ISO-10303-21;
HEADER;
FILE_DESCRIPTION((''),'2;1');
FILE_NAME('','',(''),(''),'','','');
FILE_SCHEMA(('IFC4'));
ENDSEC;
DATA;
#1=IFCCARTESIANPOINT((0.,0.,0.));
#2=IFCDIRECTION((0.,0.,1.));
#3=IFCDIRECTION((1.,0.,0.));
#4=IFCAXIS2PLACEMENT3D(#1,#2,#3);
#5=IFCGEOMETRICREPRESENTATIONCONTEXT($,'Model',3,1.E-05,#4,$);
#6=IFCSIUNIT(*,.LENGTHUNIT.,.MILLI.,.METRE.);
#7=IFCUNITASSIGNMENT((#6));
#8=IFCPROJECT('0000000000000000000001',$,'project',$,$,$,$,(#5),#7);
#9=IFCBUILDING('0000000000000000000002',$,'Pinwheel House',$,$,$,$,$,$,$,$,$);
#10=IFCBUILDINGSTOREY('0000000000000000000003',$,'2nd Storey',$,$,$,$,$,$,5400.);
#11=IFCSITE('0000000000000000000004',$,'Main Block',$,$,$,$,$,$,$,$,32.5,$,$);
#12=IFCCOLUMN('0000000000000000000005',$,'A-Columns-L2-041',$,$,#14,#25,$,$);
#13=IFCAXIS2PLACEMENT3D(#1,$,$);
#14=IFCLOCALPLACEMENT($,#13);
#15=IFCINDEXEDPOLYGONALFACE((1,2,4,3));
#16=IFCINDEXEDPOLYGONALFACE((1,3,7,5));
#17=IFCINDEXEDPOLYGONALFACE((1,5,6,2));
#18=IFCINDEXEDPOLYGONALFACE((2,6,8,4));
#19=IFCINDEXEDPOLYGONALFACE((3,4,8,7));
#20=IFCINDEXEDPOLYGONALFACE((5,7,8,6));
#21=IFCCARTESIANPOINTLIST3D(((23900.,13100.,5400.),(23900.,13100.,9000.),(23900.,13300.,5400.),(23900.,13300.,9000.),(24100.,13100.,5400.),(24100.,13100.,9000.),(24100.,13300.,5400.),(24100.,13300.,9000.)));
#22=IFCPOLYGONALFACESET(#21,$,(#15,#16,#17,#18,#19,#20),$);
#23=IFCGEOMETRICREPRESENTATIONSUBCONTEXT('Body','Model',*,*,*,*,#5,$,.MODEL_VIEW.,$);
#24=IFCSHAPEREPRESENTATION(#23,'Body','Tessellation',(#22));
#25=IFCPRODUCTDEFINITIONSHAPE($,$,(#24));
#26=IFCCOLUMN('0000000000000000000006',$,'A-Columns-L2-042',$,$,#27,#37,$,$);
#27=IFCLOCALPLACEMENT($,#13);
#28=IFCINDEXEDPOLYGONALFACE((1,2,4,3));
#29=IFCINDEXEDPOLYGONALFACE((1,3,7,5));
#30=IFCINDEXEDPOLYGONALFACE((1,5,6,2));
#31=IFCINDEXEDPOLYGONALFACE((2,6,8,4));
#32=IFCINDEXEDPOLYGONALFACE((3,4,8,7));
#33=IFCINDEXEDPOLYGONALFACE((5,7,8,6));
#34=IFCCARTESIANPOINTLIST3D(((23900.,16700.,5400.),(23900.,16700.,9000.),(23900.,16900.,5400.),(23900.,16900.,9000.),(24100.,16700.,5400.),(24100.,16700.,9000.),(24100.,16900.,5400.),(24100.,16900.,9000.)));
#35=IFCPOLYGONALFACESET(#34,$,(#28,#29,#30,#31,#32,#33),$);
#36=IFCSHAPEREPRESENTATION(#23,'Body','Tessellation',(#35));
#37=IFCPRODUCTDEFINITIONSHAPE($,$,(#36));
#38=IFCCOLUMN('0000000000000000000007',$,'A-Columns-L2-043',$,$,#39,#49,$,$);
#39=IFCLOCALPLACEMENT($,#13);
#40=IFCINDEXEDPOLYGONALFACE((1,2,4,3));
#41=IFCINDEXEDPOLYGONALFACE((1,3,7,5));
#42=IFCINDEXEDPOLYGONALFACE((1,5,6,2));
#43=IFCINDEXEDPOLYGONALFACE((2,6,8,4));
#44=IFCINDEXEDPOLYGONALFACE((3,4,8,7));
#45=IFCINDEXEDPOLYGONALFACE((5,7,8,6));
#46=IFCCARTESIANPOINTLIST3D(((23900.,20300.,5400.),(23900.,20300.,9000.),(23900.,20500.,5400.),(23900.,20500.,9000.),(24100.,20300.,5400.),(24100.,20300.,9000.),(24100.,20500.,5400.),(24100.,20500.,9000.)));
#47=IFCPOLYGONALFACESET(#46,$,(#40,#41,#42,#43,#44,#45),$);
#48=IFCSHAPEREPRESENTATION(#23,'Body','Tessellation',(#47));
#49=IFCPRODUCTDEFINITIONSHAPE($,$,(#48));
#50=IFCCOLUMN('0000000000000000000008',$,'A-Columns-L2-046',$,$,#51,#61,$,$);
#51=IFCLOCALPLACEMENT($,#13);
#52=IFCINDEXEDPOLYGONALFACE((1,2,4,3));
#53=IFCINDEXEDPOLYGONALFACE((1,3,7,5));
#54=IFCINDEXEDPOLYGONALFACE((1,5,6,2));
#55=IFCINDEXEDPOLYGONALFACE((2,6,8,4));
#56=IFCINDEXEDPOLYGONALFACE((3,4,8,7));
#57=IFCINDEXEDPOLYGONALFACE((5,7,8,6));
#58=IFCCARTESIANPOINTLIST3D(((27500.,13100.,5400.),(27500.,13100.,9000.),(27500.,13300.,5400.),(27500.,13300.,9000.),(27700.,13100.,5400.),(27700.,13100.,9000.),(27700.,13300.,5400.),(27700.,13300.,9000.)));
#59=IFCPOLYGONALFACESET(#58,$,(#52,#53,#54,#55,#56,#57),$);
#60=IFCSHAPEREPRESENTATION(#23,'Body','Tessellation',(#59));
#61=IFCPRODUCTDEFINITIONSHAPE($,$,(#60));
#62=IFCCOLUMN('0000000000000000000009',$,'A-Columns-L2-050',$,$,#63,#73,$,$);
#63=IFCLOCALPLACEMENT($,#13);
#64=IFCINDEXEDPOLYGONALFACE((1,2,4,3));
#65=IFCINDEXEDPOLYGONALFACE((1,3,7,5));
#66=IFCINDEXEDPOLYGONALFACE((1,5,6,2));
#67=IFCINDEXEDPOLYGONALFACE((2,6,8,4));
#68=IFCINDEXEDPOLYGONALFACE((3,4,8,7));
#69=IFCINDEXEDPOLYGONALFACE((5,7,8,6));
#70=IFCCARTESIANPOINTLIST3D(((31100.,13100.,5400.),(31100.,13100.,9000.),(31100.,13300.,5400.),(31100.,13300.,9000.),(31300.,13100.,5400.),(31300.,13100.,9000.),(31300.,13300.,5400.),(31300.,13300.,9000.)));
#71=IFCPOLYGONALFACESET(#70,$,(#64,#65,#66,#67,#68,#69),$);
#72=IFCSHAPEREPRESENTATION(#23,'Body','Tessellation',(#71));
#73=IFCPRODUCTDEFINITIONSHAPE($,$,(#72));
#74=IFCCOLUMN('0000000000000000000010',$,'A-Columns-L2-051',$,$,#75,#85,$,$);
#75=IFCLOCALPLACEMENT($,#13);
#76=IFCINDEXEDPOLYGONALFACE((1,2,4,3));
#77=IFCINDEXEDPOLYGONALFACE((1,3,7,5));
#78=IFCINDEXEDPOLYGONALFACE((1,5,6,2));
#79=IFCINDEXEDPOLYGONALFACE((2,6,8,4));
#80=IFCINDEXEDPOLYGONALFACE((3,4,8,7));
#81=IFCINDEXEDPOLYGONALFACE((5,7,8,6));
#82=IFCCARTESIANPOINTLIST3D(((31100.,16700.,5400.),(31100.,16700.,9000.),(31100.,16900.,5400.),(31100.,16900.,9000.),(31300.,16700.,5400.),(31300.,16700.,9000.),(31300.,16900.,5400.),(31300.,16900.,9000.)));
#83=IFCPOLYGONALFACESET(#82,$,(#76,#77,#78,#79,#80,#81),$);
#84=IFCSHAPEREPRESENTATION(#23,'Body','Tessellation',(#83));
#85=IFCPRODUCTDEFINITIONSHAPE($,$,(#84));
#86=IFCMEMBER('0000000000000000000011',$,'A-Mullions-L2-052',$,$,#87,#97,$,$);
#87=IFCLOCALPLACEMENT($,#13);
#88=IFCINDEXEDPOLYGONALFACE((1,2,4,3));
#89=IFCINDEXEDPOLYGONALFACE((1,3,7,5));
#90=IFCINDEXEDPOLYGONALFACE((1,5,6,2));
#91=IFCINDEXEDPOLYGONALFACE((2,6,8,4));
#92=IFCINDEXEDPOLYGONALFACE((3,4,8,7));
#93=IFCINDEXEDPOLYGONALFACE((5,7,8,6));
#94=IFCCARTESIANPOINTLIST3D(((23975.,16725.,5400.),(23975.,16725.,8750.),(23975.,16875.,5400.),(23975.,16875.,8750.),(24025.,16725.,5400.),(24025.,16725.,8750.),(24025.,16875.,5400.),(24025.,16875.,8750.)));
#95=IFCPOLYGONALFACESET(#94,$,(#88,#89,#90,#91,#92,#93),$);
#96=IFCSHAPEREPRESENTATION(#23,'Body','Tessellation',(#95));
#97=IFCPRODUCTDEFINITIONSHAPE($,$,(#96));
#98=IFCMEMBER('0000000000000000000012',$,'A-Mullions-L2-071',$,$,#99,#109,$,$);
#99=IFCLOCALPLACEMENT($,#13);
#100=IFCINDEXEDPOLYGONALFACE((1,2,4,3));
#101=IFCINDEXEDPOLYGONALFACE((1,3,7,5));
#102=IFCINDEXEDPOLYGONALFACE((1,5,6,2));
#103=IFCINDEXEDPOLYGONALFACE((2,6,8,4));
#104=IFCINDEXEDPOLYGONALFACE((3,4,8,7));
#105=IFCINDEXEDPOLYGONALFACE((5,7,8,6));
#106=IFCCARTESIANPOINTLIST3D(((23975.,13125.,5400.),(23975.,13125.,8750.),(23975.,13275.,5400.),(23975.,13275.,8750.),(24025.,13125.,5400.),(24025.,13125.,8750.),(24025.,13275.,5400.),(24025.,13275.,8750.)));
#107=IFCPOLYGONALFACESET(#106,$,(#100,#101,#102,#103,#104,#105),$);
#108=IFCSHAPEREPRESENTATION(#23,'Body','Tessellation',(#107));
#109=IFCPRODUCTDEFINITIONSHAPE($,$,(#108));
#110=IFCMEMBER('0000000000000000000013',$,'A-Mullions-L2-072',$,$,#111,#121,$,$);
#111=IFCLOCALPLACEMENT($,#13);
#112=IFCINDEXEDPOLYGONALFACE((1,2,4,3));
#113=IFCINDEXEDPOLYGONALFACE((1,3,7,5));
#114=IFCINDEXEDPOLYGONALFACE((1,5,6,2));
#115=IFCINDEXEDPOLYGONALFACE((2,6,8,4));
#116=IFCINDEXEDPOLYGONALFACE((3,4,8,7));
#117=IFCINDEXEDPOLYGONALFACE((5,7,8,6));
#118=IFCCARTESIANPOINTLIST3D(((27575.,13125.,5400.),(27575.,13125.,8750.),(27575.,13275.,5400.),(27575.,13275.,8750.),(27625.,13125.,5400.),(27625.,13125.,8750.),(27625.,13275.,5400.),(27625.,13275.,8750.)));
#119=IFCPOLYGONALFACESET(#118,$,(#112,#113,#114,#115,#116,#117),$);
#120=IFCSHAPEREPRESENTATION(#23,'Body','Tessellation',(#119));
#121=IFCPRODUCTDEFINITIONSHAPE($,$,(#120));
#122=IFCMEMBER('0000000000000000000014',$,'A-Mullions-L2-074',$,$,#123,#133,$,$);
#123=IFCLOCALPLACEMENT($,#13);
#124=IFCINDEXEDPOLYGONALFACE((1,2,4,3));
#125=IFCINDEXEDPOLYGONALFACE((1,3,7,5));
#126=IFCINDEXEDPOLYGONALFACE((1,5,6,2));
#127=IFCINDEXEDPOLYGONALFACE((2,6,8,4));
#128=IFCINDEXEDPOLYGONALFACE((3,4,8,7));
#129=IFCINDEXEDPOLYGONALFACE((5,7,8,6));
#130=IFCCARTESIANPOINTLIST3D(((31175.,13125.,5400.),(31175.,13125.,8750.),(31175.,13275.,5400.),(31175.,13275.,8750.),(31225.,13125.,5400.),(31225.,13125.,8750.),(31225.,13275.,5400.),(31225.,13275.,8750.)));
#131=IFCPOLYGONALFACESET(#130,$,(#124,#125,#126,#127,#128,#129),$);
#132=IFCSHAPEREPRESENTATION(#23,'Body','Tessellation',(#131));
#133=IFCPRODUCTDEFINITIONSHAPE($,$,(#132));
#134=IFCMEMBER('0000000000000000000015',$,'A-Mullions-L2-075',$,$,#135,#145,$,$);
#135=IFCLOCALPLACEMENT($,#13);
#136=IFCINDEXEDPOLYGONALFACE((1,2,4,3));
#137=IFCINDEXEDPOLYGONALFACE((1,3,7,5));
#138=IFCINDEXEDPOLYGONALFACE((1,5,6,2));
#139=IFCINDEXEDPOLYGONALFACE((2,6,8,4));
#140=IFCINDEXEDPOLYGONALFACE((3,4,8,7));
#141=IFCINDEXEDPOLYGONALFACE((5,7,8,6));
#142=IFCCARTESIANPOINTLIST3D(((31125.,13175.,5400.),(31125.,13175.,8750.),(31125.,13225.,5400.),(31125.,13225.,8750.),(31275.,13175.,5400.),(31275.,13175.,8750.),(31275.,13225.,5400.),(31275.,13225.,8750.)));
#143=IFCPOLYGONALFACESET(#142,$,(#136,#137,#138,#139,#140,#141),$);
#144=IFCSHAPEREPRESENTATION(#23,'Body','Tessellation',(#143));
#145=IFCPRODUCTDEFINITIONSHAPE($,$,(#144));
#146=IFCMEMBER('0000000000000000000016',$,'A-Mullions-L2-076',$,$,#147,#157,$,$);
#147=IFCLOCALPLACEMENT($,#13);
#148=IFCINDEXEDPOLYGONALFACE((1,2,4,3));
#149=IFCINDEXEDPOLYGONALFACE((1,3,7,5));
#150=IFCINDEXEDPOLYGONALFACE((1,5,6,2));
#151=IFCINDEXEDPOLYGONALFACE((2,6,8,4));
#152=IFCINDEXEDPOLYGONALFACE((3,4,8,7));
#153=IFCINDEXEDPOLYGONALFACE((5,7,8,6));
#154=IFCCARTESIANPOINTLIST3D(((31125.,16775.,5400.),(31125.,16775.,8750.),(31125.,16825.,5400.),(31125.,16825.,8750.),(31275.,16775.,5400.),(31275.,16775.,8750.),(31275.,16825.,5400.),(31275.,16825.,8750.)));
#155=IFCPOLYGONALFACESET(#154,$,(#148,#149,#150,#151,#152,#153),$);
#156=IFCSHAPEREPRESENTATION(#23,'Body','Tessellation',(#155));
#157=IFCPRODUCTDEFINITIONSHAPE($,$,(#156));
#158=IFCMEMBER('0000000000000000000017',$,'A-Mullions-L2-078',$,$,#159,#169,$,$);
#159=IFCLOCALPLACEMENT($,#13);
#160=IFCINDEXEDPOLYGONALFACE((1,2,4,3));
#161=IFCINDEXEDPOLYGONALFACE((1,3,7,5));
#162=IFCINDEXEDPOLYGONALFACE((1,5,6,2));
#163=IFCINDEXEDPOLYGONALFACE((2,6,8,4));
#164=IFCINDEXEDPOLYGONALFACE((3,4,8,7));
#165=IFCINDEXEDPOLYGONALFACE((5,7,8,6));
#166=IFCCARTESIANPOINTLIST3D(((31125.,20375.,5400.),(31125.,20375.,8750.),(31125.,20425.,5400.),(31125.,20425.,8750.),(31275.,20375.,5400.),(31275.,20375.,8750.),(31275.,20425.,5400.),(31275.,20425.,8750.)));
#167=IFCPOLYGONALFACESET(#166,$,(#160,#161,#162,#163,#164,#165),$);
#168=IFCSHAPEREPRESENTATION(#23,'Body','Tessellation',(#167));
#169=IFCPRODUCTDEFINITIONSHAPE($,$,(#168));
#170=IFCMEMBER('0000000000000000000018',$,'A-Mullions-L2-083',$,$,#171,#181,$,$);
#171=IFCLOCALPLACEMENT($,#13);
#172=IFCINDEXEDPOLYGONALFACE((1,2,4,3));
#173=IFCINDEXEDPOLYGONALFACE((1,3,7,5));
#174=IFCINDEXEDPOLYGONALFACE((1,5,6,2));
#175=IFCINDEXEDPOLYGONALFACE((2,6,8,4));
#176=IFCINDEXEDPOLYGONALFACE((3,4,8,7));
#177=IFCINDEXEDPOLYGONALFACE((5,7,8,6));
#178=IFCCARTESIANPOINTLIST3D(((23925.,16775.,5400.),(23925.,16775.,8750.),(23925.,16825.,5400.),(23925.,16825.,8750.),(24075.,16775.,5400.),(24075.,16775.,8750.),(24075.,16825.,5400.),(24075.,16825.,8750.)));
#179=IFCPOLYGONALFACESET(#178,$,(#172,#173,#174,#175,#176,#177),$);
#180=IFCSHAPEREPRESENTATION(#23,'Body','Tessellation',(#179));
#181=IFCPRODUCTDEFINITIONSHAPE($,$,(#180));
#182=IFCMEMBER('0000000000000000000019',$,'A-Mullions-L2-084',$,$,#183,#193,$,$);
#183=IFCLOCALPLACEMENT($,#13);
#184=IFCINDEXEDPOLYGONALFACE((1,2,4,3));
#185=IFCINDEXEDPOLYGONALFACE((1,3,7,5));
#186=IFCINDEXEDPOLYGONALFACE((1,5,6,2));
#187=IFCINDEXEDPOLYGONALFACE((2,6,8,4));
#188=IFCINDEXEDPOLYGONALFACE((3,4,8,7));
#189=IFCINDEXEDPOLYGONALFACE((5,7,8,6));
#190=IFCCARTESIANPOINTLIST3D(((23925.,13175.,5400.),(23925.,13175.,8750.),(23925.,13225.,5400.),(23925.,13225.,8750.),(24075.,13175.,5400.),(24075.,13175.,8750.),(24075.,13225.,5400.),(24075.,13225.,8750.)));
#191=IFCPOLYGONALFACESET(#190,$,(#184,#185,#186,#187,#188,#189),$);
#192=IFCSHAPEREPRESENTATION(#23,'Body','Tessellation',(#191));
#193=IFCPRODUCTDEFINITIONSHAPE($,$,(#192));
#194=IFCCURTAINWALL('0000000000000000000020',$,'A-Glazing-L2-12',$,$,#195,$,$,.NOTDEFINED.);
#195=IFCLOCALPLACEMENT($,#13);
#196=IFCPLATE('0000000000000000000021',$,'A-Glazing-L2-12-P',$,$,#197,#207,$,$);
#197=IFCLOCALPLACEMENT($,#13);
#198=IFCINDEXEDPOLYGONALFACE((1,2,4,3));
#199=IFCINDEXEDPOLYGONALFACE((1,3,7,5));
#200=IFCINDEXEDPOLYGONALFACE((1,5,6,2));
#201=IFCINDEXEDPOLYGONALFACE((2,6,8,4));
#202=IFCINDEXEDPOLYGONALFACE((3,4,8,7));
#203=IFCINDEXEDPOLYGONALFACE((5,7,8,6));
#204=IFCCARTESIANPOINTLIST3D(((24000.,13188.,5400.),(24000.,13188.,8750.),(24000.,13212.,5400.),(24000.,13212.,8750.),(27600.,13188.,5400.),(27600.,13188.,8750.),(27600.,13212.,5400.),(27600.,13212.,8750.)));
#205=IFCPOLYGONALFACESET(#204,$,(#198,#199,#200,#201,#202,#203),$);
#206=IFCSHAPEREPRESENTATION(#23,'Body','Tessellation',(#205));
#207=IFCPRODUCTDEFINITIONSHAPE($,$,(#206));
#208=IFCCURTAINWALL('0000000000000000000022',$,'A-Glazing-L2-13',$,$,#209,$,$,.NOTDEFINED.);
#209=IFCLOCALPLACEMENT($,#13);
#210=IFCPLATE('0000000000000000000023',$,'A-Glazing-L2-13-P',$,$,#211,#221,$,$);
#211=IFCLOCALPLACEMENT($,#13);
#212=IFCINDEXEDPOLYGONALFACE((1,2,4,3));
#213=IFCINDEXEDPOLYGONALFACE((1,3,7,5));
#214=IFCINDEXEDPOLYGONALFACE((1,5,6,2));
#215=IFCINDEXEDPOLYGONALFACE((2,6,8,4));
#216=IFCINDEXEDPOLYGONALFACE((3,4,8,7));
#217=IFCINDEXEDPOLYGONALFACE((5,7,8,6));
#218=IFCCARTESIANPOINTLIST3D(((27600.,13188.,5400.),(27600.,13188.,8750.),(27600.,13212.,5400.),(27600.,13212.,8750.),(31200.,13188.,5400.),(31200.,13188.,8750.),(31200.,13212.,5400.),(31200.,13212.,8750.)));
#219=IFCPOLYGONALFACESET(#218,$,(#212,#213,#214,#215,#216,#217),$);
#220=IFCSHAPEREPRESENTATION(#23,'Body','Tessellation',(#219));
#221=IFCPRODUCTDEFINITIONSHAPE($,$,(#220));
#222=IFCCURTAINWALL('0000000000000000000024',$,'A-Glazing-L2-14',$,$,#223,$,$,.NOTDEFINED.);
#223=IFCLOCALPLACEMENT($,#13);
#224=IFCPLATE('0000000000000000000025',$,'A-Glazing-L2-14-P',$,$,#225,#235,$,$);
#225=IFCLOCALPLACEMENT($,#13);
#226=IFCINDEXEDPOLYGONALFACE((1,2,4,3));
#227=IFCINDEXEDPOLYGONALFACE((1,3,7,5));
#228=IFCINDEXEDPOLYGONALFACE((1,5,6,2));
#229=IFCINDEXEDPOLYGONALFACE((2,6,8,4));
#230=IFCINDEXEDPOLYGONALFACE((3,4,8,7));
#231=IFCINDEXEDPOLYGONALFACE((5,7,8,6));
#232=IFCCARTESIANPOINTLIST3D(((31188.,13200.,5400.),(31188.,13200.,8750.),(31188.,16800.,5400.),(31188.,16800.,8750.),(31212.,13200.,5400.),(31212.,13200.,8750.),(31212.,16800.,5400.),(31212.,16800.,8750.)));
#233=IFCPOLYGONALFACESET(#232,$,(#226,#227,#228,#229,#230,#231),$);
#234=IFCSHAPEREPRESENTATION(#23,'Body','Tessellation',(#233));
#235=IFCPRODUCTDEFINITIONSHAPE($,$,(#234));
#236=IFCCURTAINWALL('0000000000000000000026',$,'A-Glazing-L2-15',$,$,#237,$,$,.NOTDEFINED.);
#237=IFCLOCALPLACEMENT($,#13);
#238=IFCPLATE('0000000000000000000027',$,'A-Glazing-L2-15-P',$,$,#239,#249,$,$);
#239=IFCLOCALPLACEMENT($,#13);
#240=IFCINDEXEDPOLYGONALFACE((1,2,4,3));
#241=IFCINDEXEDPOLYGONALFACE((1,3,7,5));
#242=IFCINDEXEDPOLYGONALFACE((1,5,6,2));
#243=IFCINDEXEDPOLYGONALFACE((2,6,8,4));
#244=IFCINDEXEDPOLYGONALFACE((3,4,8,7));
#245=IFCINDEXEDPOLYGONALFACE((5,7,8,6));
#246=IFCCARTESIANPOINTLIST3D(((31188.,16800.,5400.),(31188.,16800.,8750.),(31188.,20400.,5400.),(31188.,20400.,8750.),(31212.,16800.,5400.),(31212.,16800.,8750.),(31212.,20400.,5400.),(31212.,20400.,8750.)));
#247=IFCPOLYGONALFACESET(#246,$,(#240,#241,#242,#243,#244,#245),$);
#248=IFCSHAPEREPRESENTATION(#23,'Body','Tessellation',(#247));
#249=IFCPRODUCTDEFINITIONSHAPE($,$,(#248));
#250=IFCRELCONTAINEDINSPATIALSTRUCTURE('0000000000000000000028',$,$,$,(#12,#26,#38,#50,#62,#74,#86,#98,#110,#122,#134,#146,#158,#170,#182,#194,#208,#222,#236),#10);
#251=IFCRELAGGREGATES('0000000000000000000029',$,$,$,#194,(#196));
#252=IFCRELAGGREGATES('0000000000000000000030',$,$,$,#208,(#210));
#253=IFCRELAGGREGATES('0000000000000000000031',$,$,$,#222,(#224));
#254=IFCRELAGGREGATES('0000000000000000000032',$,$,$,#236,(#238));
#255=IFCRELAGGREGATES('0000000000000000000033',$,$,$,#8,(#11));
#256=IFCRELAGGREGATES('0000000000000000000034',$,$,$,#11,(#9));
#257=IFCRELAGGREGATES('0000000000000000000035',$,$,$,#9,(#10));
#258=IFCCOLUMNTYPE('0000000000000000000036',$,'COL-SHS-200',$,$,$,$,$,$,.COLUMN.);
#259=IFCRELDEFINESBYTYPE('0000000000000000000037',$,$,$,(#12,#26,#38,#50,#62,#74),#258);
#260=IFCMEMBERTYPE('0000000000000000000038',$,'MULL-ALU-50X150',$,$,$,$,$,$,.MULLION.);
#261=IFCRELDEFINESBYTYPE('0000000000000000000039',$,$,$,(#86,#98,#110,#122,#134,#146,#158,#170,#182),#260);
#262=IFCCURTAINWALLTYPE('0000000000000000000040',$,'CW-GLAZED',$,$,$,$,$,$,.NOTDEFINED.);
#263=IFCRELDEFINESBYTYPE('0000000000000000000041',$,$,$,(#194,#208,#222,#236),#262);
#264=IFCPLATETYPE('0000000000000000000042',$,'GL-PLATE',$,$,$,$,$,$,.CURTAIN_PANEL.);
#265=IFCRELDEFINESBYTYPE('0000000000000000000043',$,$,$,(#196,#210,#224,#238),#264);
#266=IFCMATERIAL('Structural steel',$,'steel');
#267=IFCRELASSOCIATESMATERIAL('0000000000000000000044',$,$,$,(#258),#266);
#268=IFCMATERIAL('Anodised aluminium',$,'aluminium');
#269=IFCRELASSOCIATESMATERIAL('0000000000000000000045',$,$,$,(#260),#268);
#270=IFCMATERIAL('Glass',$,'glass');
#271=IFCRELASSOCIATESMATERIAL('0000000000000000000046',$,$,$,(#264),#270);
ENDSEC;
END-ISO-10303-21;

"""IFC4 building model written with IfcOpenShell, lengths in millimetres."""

from ifc_helpers import new_model, si_unit, frame, origin_with_axes, place, context, subcontext, project, spatial, indexed_curve, outline, extrude, material, type_object, element, aggregate, save


model = new_model("IFC4")

# Units and contexts
model_context = context("Model", 3, precision=1e-05, world=origin_with_axes())
body_context = subcontext(model_context, "Body", "Model", "MODEL_VIEW")
ifc_project = project(units=[si_unit("LENGTHUNIT", "METRE", prefix="MILLI")], contexts=[model_context])

# Site, building, storey
site = spatial("IfcSite", under=ifc_project, Name="Main Block", RefElevation=32.5)
building = spatial("IfcBuilding", under=site, Name="Pinwheel House")
storey = spatial("IfcBuildingStorey", under=building, Name="2nd Storey", Elevation=5400.0)

# Columns
ifc_material_1 = material(Name="Structural steel", Category="steel")
column_type = type_object("IfcColumnType", Name="COL-SHS-200", PredefinedType="COLUMN", material=ifc_material_1)
for number, where, z_axis, x_axis, name in (
    (1, (24000.0, 13200.0, 5400.0), (0.0, 0.0, 1.0), (1.0, 0.0, 0.0), "A-Columns-L2-041"),
    (2, (24000.0, 16800.0, 5400.0), (0.0, 0.0, 1.0), (1.0, 0.0, 0.0), "A-Columns-L2-042"),
    (3, (24000.0, 20400.0, 5400.0), (0.0, 0.0, 1.0), (1.0, 0.0, 0.0), "A-Columns-L2-043"),
    (4, (27600.0, 13200.0, 5400.0), (0.0, 0.0, 1.0), (1.0, 0.0, 0.0), "A-Columns-L2-046"),
    (5, (31200.0, 13200.0, 5400.0), (0.0, 0.0, 1.0), (1.0, 0.0, 0.0), "A-Columns-L2-050"),
    (6, (31200.0, 16800.0, 5400.0), (0.0, 0.0, 1.0), (1.0, 0.0, 0.0), "A-Columns-L2-051"),
):
    element("IfcColumn", number, at=place(None, frame(where, z_axis=z_axis, x_axis=x_axis)), inside=storey, type_object=column_type, Name=name, context=body_context, shape_type="SweptSolid", body=[
        extrude(outline(indexed_curve([(-100.0, -100.0), (100.0, -100.0), (100.0, 100.0), (-100.0, 100.0)])), None, (0.0, 0.0, 1.0), 3600.0),
    ])

# Members
ifc_material_2 = material(Name="Anodised aluminium", Category="aluminium")
member_type = type_object("IfcMemberType", Name="MULL-ALU-50X150", PredefinedType="MULLION", material=ifc_material_2)
for number, where, z_axis, x_axis, name in (
    (7, (24000.0, 16800.0, 5400.0), (0.0, 0.0, 1.0), (1.0, 0.0, 0.0), "A-Mullions-L2-052"),
    (8, (24000.0, 13200.0, 5400.0), (0.0, 0.0, 1.0), (1.0, 0.0, 0.0), "A-Mullions-L2-071"),
    (9, (27600.0, 13200.0, 5400.0), (0.0, 0.0, 1.0), (1.0, 0.0, 0.0), "A-Mullions-L2-072"),
    (10, (31200.0, 13200.0, 5400.0), (0.0, 0.0, 1.0), (1.0, 0.0, 0.0), "A-Mullions-L2-074"),
    (11, (31200.0, 13200.0, 5400.0), (0.0, 0.0, 1.0), (0.0, 1.0, 0.0), "A-Mullions-L2-075"),
    (12, (31200.0, 16800.0, 5400.0), (0.0, 0.0, 1.0), (0.0, 1.0, 0.0), "A-Mullions-L2-076"),
    (13, (31200.0, 20400.0, 5400.0), (0.0, 0.0, 1.0), (0.0, 1.0, 0.0), "A-Mullions-L2-078"),
    (14, (24000.0, 16800.0, 5400.0), (0.0, 0.0, 1.0), (0.0, -1.0, 0.0), "A-Mullions-L2-083"),
    (15, (24000.0, 13200.0, 5400.0), (0.0, 0.0, 1.0), (0.0, -1.0, 0.0), "A-Mullions-L2-084"),
):
    element("IfcMember", number, at=place(None, frame(where, z_axis=z_axis, x_axis=x_axis)), inside=storey, type_object=member_type, Name=name, context=body_context, shape_type="SweptSolid", body=[
        extrude(outline(indexed_curve([(-25.0, -75.0), (25.0, -75.0), (25.0, 75.0), (-25.0, 75.0)])), None, (0.0, 0.0, 1.0), 3350.0),
    ])

# Curtain walls, plates
curtain_wall_type = type_object("IfcCurtainWallType", Name="CW-GLAZED", PredefinedType="NOTDEFINED")
curtain_wall_1 = element("IfcCurtainWall", 16, inside=storey, type_object=curtain_wall_type, Name="A-Glazing-L2-12", PredefinedType="NOTDEFINED")
ifc_material_3 = material(Name="Glass", Category="glass")
plate_type = type_object("IfcPlateType", Name="GL-PLATE", PredefinedType="CURTAIN_PANEL", material=ifc_material_3)
plate_1_placement = place(None, frame((25800.0, 13200.0, 5400.0), z_axis=(0.0, 0.0, 1.0), x_axis=(1.0, 0.0, 0.0)))
plate_1 = element("IfcPlate", 17, at=plate_1_placement, type_object=plate_type, Name="A-Glazing-L2-12-P", context=body_context, shape_type="SweptSolid", body=[
    extrude(outline(indexed_curve([(-1800.0, -12.0), (1800.0, -12.0), (1800.0, 12.0), (-1800.0, 12.0)])), None, (0.0, 0.0, 1.0), 3350.0),
])
aggregate(curtain_wall_1, [plate_1])
curtain_wall_2 = element("IfcCurtainWall", 18, inside=storey, type_object=curtain_wall_type, Name="A-Glazing-L2-13", PredefinedType="NOTDEFINED")
plate_2_placement = place(None, frame((29400.0, 13200.0, 5400.0), z_axis=(0.0, 0.0, 1.0), x_axis=(1.0, 0.0, 0.0)))
plate_2 = element("IfcPlate", 19, at=plate_2_placement, type_object=plate_type, Name="A-Glazing-L2-13-P", context=body_context, shape_type="SweptSolid", body=[
    extrude(outline(indexed_curve([(-1800.0, -12.0), (1800.0, -12.0), (1800.0, 12.0), (-1800.0, 12.0)])), None, (0.0, 0.0, 1.0), 3350.0),
])
aggregate(curtain_wall_2, [plate_2])
curtain_wall_3 = element("IfcCurtainWall", 20, inside=storey, type_object=curtain_wall_type, Name="A-Glazing-L2-14", PredefinedType="NOTDEFINED")
plate_3_placement = place(None, frame((31200.0, 15000.0, 5400.0), z_axis=(0.0, 0.0, 1.0), x_axis=(0.0, 1.0, 0.0)))
plate_3 = element("IfcPlate", 21, at=plate_3_placement, type_object=plate_type, Name="A-Glazing-L2-14-P", context=body_context, shape_type="SweptSolid", body=[
    extrude(outline(indexed_curve([(-1800.0, -12.0), (1800.0, -12.0), (1800.0, 12.0), (-1800.0, 12.0)])), None, (0.0, 0.0, 1.0), 3350.0),
])
aggregate(curtain_wall_3, [plate_3])
curtain_wall_4 = element("IfcCurtainWall", 22, inside=storey, type_object=curtain_wall_type, Name="A-Glazing-L2-15", PredefinedType="NOTDEFINED")
plate_4_placement = place(None, frame((31200.0, 18600.0, 5400.0), z_axis=(0.0, 0.0, 1.0), x_axis=(0.0, 1.0, 0.0)))
plate_4 = element("IfcPlate", 23, at=plate_4_placement, type_object=plate_type, Name="A-Glazing-L2-15-P", context=body_context, shape_type="SweptSolid", body=[
    extrude(outline(indexed_curve([(-1800.0, -12.0), (1800.0, -12.0), (1800.0, 12.0), (-1800.0, 12.0)])), None, (0.0, 0.0, 1.0), 3350.0),
])
aggregate(curtain_wall_4, [plate_4])

save(model, "model.ifc")
